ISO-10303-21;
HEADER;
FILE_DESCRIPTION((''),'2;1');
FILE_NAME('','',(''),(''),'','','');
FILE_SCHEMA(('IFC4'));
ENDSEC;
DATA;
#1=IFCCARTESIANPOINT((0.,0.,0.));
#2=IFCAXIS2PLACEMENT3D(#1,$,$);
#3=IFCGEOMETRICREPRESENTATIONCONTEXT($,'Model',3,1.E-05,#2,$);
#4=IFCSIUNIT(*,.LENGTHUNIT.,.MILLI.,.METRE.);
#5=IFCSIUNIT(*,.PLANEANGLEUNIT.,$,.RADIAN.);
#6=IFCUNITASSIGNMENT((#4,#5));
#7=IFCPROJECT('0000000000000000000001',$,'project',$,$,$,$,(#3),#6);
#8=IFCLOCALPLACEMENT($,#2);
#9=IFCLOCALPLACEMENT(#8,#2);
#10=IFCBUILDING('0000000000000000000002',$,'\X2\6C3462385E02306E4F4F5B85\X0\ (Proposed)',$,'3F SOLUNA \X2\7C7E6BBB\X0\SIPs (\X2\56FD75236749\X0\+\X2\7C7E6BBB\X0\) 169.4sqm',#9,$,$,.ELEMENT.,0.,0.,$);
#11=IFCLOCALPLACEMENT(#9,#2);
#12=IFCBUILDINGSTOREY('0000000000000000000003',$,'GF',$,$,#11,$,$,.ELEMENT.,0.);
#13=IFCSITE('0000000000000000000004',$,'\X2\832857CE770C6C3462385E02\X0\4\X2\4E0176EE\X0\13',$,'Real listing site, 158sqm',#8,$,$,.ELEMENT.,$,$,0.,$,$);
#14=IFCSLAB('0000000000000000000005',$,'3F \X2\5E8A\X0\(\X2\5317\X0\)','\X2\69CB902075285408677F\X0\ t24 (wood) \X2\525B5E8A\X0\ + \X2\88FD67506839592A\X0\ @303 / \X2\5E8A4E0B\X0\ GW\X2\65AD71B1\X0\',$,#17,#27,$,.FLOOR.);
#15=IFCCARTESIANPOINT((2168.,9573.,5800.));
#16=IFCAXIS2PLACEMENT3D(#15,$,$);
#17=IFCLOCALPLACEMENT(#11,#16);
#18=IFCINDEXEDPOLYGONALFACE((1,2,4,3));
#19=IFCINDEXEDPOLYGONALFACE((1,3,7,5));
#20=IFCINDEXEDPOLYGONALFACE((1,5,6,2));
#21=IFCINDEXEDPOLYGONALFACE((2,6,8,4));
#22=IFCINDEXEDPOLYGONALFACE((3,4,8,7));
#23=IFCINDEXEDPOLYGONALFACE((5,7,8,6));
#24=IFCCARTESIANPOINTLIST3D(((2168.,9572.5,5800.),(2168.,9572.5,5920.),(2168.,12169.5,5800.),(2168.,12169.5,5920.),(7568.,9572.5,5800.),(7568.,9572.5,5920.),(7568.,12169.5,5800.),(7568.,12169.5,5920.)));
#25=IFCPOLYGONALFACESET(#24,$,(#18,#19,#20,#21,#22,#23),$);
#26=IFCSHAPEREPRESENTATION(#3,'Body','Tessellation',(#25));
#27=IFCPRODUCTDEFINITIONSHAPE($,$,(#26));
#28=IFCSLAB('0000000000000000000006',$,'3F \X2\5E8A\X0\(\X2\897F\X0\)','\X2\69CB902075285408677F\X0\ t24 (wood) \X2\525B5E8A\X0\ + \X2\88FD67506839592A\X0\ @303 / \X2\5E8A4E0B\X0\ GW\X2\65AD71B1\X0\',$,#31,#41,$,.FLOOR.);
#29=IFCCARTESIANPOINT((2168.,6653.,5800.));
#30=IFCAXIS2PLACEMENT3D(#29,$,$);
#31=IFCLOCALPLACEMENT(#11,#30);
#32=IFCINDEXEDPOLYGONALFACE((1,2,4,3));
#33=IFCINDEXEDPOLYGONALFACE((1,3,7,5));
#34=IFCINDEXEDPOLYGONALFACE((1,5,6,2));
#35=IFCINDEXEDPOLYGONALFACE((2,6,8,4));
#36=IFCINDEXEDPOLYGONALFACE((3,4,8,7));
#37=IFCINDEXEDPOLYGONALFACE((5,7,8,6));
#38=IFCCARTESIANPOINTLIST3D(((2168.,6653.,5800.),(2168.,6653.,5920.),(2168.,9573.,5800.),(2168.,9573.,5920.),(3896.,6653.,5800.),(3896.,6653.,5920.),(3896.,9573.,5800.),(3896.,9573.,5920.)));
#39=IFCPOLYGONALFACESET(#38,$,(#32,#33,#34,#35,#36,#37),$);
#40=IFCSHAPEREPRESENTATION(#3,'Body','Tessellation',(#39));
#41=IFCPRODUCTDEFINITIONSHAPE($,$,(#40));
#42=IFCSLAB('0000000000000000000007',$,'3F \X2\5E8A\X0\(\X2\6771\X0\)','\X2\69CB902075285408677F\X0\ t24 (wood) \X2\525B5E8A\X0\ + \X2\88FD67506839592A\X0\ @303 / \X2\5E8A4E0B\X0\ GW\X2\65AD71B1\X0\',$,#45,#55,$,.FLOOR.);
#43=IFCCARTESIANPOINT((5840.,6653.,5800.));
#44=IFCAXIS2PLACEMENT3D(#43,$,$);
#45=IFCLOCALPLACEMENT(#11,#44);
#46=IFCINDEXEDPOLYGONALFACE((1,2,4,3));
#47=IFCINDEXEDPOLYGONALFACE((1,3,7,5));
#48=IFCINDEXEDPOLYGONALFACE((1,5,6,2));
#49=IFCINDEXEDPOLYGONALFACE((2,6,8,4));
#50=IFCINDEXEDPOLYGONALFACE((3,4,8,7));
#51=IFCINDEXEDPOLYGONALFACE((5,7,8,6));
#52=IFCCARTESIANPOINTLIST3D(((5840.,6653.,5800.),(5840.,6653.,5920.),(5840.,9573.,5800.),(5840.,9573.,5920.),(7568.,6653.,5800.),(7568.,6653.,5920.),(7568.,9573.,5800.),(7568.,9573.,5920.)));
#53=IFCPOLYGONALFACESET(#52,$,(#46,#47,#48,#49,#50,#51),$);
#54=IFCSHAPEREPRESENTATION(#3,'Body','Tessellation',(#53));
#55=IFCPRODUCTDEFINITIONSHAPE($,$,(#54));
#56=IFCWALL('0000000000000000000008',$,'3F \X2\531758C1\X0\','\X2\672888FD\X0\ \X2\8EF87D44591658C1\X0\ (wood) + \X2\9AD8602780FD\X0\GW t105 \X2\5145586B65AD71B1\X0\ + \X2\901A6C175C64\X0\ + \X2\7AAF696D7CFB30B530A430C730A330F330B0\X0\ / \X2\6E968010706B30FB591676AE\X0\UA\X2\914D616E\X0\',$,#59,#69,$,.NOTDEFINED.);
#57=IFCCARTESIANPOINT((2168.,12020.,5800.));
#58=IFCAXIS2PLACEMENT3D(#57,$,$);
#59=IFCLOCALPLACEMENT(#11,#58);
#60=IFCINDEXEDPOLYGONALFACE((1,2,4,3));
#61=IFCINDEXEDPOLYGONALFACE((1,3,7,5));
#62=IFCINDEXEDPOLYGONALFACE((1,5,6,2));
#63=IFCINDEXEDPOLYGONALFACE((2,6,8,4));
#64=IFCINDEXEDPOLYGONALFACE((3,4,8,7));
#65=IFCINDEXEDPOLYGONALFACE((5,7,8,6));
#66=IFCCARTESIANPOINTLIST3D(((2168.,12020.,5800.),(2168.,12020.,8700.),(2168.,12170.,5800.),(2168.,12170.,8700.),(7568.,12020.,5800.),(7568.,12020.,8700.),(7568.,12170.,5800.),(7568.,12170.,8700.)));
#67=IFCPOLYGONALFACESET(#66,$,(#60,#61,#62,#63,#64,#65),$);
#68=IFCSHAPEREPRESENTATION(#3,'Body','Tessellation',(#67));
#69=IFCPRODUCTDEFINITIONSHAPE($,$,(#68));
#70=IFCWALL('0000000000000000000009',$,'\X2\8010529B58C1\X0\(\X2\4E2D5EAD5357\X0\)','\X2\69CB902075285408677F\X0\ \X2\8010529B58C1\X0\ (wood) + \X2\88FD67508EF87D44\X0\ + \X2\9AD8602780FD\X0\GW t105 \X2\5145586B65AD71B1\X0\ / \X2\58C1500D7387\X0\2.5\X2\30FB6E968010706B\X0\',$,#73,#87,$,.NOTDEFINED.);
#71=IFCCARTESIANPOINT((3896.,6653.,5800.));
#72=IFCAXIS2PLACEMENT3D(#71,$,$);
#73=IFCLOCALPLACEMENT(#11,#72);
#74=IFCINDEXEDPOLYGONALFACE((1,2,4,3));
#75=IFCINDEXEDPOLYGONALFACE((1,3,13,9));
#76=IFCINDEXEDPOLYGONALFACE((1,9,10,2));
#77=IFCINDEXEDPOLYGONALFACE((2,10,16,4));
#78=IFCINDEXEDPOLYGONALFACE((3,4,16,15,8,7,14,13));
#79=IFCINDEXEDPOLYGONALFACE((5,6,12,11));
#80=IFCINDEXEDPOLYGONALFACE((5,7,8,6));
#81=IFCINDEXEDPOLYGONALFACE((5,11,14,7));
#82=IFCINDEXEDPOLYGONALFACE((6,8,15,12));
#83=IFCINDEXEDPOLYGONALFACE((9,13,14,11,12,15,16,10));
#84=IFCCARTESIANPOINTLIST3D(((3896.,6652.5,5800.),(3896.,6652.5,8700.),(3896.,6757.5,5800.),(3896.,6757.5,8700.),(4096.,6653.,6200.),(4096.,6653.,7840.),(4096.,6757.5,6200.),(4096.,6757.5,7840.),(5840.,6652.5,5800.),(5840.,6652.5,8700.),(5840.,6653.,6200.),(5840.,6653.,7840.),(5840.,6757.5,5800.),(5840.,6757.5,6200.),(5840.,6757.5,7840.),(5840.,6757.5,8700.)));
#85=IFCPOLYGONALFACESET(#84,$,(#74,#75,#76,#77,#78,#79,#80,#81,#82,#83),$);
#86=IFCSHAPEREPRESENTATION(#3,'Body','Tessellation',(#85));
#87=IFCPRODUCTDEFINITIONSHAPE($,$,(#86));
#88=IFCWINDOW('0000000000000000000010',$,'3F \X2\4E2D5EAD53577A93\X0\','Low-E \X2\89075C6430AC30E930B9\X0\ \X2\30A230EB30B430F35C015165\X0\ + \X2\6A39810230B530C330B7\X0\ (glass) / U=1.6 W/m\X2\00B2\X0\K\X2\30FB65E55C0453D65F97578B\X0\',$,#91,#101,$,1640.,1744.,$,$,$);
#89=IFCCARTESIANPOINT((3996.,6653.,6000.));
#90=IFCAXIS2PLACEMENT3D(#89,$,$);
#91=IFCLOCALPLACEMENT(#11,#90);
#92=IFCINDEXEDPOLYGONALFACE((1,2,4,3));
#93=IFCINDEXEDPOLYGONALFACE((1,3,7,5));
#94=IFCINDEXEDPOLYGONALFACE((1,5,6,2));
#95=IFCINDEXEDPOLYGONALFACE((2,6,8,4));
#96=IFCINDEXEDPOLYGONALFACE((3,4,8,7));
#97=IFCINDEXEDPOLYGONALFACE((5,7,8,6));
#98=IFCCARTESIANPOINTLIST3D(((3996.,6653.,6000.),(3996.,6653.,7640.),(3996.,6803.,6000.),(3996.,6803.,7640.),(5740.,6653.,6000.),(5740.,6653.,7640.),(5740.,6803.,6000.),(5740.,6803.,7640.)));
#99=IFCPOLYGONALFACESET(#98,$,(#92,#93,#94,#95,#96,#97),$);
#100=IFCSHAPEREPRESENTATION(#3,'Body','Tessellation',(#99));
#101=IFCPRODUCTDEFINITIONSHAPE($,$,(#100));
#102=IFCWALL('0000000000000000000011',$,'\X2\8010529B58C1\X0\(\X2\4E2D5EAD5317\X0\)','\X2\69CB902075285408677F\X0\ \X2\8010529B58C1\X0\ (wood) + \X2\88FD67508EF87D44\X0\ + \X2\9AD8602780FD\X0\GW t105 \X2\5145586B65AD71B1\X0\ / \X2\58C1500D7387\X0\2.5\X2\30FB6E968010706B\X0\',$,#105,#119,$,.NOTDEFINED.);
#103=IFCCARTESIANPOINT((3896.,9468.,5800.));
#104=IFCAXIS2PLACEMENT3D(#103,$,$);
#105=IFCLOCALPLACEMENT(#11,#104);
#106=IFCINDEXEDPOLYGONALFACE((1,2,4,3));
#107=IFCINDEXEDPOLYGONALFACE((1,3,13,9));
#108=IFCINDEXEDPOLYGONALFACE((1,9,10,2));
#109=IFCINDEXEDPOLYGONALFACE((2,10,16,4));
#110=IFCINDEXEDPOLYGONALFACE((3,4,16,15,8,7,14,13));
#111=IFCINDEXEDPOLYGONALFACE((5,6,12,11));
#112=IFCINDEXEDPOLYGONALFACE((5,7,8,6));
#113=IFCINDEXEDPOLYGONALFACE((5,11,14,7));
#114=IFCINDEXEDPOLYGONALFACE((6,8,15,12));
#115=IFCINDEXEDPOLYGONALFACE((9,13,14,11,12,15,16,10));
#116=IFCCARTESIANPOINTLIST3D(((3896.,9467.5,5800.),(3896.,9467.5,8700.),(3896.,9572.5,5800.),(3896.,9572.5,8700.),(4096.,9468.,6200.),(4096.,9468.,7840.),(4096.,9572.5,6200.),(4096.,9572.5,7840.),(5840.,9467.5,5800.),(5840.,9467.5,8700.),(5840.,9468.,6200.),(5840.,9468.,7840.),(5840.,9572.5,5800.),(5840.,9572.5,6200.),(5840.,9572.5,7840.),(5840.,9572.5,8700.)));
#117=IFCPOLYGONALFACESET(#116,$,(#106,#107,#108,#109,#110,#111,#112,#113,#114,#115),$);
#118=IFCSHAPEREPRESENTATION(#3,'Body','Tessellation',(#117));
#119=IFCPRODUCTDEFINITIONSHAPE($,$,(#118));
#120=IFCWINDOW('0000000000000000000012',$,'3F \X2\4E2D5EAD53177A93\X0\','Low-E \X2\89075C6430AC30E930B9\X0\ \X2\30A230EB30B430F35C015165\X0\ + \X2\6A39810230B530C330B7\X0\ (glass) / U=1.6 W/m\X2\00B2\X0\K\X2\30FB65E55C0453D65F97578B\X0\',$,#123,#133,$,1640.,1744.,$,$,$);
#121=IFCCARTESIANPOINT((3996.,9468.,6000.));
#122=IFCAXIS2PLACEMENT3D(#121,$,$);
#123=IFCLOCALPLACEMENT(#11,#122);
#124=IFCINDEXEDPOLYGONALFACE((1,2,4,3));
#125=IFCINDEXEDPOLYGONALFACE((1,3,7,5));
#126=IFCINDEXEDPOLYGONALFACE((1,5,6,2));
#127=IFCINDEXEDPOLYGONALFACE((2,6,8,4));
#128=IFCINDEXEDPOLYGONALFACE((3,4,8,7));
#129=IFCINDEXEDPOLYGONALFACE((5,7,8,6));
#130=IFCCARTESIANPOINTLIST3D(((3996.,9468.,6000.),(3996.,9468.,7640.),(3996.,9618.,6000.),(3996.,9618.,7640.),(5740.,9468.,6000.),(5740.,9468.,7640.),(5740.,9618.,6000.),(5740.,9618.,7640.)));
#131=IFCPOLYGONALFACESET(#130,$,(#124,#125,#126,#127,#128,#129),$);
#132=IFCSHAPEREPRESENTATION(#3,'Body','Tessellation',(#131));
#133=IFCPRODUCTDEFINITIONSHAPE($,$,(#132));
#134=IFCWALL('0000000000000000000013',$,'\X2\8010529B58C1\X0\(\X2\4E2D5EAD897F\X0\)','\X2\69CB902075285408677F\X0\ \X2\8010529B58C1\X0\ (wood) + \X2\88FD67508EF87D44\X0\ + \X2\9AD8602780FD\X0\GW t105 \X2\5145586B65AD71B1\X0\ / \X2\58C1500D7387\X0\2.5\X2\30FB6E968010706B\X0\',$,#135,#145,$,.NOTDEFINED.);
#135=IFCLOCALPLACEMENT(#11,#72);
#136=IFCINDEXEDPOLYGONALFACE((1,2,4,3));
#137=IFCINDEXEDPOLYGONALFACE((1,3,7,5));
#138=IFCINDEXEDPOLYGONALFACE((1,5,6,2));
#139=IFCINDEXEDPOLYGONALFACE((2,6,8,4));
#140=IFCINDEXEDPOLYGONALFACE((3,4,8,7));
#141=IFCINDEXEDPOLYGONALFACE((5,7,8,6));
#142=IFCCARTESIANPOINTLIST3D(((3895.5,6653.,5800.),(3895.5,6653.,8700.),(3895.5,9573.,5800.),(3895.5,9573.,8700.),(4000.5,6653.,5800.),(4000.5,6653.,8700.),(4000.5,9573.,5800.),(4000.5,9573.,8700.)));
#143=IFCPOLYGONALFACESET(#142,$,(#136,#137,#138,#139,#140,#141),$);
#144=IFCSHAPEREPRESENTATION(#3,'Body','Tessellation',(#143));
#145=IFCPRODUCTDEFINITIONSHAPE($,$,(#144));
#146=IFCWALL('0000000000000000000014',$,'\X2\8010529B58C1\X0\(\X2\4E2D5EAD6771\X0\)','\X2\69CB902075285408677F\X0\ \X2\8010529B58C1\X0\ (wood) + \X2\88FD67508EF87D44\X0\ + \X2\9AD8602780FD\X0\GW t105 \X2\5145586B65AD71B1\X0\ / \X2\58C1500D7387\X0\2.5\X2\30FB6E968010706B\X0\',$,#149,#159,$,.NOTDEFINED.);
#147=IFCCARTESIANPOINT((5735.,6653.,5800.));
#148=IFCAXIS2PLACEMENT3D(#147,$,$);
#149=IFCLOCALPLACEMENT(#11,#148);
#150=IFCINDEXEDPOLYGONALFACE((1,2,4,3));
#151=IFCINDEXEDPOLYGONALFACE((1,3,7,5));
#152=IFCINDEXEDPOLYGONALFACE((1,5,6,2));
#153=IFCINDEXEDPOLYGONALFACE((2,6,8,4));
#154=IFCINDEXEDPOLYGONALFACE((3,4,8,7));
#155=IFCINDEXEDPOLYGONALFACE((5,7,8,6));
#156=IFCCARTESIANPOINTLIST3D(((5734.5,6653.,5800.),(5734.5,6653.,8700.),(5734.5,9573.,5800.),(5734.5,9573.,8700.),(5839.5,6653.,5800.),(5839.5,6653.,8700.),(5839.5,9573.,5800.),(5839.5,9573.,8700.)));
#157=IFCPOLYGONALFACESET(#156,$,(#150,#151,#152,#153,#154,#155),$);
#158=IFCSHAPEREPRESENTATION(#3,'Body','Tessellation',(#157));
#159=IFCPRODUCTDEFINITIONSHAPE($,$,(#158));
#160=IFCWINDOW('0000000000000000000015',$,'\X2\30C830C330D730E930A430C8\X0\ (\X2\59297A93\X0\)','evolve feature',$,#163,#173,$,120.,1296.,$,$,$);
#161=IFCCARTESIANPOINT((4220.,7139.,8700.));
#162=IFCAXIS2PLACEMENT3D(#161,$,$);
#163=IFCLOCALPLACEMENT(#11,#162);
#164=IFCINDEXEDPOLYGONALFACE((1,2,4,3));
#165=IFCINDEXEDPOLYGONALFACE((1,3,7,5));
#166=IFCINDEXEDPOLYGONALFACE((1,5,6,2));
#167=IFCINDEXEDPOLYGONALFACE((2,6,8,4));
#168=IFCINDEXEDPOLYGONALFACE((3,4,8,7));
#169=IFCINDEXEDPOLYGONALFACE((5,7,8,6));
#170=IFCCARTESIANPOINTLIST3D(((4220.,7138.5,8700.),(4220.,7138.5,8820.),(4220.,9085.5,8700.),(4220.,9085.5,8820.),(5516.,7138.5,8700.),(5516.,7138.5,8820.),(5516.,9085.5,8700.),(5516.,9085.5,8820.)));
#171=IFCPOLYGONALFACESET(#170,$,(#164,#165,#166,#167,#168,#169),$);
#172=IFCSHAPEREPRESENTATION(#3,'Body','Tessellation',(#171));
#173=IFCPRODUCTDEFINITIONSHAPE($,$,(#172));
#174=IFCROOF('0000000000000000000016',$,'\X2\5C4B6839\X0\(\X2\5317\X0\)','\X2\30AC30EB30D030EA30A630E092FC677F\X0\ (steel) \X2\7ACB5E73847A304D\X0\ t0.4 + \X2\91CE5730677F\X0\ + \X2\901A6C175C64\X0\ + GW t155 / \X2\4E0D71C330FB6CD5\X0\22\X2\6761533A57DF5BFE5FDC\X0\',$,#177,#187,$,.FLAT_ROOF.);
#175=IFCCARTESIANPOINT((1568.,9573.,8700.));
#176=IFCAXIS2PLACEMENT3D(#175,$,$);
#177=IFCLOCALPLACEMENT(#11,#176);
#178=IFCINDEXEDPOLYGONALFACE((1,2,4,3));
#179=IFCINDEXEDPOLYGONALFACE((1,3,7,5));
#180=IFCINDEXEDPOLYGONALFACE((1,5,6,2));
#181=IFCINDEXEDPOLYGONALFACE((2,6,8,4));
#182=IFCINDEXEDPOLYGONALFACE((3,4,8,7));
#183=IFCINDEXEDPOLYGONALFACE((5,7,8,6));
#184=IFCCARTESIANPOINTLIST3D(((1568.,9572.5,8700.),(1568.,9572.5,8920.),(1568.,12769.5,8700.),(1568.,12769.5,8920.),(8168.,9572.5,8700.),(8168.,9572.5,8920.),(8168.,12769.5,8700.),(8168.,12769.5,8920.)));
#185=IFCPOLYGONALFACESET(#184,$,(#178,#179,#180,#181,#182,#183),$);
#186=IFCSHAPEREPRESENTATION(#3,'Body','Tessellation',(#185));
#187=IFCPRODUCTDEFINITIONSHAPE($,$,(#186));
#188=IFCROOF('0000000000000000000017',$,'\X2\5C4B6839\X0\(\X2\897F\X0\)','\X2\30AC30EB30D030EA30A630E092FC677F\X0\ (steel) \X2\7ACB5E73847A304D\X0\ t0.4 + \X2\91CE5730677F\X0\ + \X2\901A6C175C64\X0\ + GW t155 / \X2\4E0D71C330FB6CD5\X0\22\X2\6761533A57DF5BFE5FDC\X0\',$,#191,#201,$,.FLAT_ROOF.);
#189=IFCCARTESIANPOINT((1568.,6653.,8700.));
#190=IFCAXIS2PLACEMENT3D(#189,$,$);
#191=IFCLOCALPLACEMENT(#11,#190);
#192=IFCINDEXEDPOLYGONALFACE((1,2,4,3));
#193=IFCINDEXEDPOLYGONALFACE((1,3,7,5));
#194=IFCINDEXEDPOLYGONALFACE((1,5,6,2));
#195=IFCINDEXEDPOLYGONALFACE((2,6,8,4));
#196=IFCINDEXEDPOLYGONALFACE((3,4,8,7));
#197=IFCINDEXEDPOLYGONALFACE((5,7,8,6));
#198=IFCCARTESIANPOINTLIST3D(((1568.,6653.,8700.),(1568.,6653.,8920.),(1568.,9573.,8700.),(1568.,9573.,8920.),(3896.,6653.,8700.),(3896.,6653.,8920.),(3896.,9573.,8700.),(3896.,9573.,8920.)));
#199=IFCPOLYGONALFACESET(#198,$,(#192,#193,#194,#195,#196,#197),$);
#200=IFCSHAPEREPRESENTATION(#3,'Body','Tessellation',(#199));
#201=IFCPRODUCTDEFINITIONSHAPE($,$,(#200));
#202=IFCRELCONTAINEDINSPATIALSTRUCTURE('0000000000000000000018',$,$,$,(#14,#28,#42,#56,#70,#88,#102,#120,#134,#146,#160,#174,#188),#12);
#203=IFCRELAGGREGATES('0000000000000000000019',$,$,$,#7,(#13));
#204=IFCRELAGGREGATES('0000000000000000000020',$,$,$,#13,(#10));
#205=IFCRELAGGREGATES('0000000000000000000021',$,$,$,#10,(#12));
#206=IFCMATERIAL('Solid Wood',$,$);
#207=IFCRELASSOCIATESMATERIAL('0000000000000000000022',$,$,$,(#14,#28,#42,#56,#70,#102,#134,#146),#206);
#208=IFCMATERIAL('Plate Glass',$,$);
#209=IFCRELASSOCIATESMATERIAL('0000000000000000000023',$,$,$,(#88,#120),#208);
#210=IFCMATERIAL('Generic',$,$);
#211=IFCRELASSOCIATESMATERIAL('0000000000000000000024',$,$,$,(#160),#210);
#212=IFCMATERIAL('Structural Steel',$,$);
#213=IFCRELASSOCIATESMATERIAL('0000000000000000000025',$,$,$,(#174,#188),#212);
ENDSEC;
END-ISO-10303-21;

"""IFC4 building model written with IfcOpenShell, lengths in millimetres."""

from ifc_helpers import new_model, si_unit, frame, frame_2d, origin, place, context, project, spatial, rectangle, extrude, material, element, fill, save


model = new_model("IFC4")

# Units and contexts
model_context = context("Model", 3, precision=1e-05, world=origin())
ifc_project = project(units=[si_unit("LENGTHUNIT", "METRE", prefix="MILLI"), si_unit("PLANEANGLEUNIT", "RADIAN")], contexts=[model_context])

# Site, building, storey
site_placement = place(None, origin())
site = spatial("IfcSite", under=ifc_project, at=site_placement, Name="茨城県水戸市4丁目13", ObjectType="Real listing site, 158sqm", CompositionType="ELEMENT", RefElevation=0.0)
building_placement = place(site_placement, origin())
building = spatial("IfcBuilding", under=site, at=building_placement, Name="水戸市の住宅 (Proposed)", ObjectType="3F SOLUNA 籾殻SIPs (国産杉+籾殻) 169.4sqm", CompositionType="ELEMENT", ElevationOfRefHeight=0.0, ElevationOfTerrain=0.0)
storey_placement = place(building_placement, origin())
storey = spatial("IfcBuildingStorey", under=building, at=storey_placement, Name="GF", CompositionType="ELEMENT", Elevation=0.0)

# Slabs
ifc_material_1 = material(Name="Solid Wood")
slab_1_placement = place(storey_placement, frame((2168.0, 9573.0, 5800.0)))
element("IfcSlab", 1, at=slab_1_placement, inside=storey, material=ifc_material_1, Name="3F 床(北)", Description="構造用合板 t24 (wood) 剛床 + 製材根太 @303 / 床下 GW断熱", PredefinedType="FLOOR", context=model_context, shape_type="SweptSolid", body=[
    extrude(rectangle(XDim=5400.0, YDim=2597.0, at=frame_2d((2700.0, 1298.0))), frame((2168.0, 9573.0, 5800.0)), (0.0, 0.0, 1.0), 120.0),
])
slab_2_placement = place(storey_placement, frame((2168.0, 6653.0, 5800.0)))
element("IfcSlab", 2, at=slab_2_placement, inside=storey, material=ifc_material_1, Name="3F 床(西)", Description="構造用合板 t24 (wood) 剛床 + 製材根太 @303 / 床下 GW断熱", PredefinedType="FLOOR", context=model_context, shape_type="SweptSolid", body=[
    extrude(rectangle(XDim=1728.0, YDim=2920.0, at=frame_2d((864.0, 1460.0))), frame((2168.0, 6653.0, 5800.0)), (0.0, 0.0, 1.0), 120.0),
])
slab_3_placement = place(storey_placement, frame((5840.0, 6653.0, 5800.0)))
element("IfcSlab", 3, at=slab_3_placement, inside=storey, material=ifc_material_1, Name="3F 床(東)", Description="構造用合板 t24 (wood) 剛床 + 製材根太 @303 / 床下 GW断熱", PredefinedType="FLOOR", context=model_context, shape_type="SweptSolid", body=[
    extrude(rectangle(XDim=1728.0, YDim=2920.0, at=frame_2d((864.0, 1460.0))), frame((5840.0, 6653.0, 5800.0)), (0.0, 0.0, 1.0), 120.0),
])

# Wall
wall_1_placement = place(storey_placement, frame((2168.0, 12020.0, 5800.0)))
element("IfcWall", 4, at=wall_1_placement, inside=storey, material=ifc_material_1, Name="3F 北壁", Description="木製 軸組外壁 (wood) + 高性能GW t105 充填断熱 + 通気層 + 窯業系サイディング / 準耐火・外皮UA配慮", PredefinedType="NOTDEFINED", context=model_context, shape_type="SweptSolid", body=[
    extrude(rectangle(XDim=5400.0, YDim=150.0, at=frame_2d((2700.0, 75.0))), frame((2168.0, 12020.0, 5800.0)), (0.0, 0.0, 1.0), 2900.0),
])

# Walls, openings, windows
wall_2_placement = place(storey_placement, frame((3896.0, 6653.0, 5800.0)))
wall_2 = element("IfcWall", 5, at=wall_2_placement, inside=storey, material=ifc_material_1, Name="耐力壁(中庭南)", Description="構造用合板 耐力壁 (wood) + 製材軸組 + 高性能GW t105 充填断熱 / 壁倍率2.5・準耐火", PredefinedType="NOTDEFINED", context=model_context, shape_type="SweptSolid", body=[
    extrude(rectangle(XDim=1944.0, YDim=105.0, at=frame_2d((972.0, 52.0))), frame((3896.0, 6653.0, 5800.0)), (0.0, 0.0, 1.0), 2900.0),
])
opening_1_placement = place(storey_placement, frame((3996.0, 6653.0, 6000.0)))
opening_1 = element("IfcOpeningElement", 6, at=opening_1_placement, cuts=wall_2, PredefinedType="NOTDEFINED", context=model_context, shape_type="SweptSolid", body=[
    extrude(rectangle(XDim=1744.0, YDim=150.0, at=frame_2d((872.0, 75.0))), frame((3996.0, 6653.0, 6000.0)), (0.0, 0.0, 1.0), 1640.0),
])
ifc_material_2 = material(Name="Plate Glass")
window_1_placement = place(storey_placement, frame((3996.0, 6653.0, 6000.0)))
window_1 = element("IfcWindow", 7, at=window_1_placement, inside=storey, material=ifc_material_2, Name="3F 中庭南窓", Description="Low-E 複層ガラス アルゴン封入 + 樹脂サッシ (glass) / U=1.6 W/m²K・日射取得型", OverallHeight=1640.0, OverallWidth=1744.0, context=model_context, shape_type="SweptSolid", body=[
    extrude(rectangle(XDim=1744.0, YDim=150.0, at=frame_2d((872.0, 75.0))), frame((3996.0, 6653.0, 6000.0)), (0.0, 0.0, 1.0), 1640.0),
])
fill(opening_1, window_1)
wall_3_placement = place(storey_placement, frame((3896.0, 9468.0, 5800.0)))
wall_3 = element("IfcWall", 8, at=wall_3_placement, inside=storey, material=ifc_material_1, Name="耐力壁(中庭北)", Description="構造用合板 耐力壁 (wood) + 製材軸組 + 高性能GW t105 充填断熱 / 壁倍率2.5・準耐火", PredefinedType="NOTDEFINED", context=model_context, shape_type="SweptSolid", body=[
    extrude(rectangle(XDim=1944.0, YDim=105.0, at=frame_2d((972.0, 52.0))), frame((3896.0, 9468.0, 5800.0)), (0.0, 0.0, 1.0), 2900.0),
])
opening_2_placement = place(storey_placement, frame((3996.0, 9468.0, 6000.0)))
opening_2 = element("IfcOpeningElement", 9, at=opening_2_placement, cuts=wall_3, PredefinedType="NOTDEFINED", context=model_context, shape_type="SweptSolid", body=[
    extrude(rectangle(XDim=1744.0, YDim=150.0, at=frame_2d((872.0, 75.0))), frame((3996.0, 9468.0, 6000.0)), (0.0, 0.0, 1.0), 1640.0),
])
window_2_placement = place(storey_placement, frame((3996.0, 9468.0, 6000.0)))
window_2 = element("IfcWindow", 10, at=window_2_placement, inside=storey, material=ifc_material_2, Name="3F 中庭北窓", Description="Low-E 複層ガラス アルゴン封入 + 樹脂サッシ (glass) / U=1.6 W/m²K・日射取得型", OverallHeight=1640.0, OverallWidth=1744.0, context=model_context, shape_type="SweptSolid", body=[
    extrude(rectangle(XDim=1744.0, YDim=150.0, at=frame_2d((872.0, 75.0))), frame((3996.0, 9468.0, 6000.0)), (0.0, 0.0, 1.0), 1640.0),
])
fill(opening_2, window_2)

# Walls
wall_4_placement = place(storey_placement, frame((3896.0, 6653.0, 5800.0)))
element("IfcWall", 11, at=wall_4_placement, inside=storey, material=ifc_material_1, Name="耐力壁(中庭西)", Description="構造用合板 耐力壁 (wood) + 製材軸組 + 高性能GW t105 充填断熱 / 壁倍率2.5・準耐火", PredefinedType="NOTDEFINED", context=model_context, shape_type="SweptSolid", body=[
    extrude(rectangle(XDim=105.0, YDim=2920.0, at=frame_2d((52.0, 1460.0))), frame((3896.0, 6653.0, 5800.0)), (0.0, 0.0, 1.0), 2900.0),
])
wall_5_placement = place(storey_placement, frame((5735.0, 6653.0, 5800.0)))
element("IfcWall", 12, at=wall_5_placement, inside=storey, material=ifc_material_1, Name="耐力壁(中庭東)", Description="構造用合板 耐力壁 (wood) + 製材軸組 + 高性能GW t105 充填断熱 / 壁倍率2.5・準耐火", PredefinedType="NOTDEFINED", context=model_context, shape_type="SweptSolid", body=[
    extrude(rectangle(XDim=105.0, YDim=2920.0, at=frame_2d((52.0, 1460.0))), frame((5735.0, 6653.0, 5800.0)), (0.0, 0.0, 1.0), 2900.0),
])

# Window
ifc_material_3 = material(Name="Generic")
window_3_placement = place(storey_placement, frame((4220.0, 7139.0, 8700.0)))
element("IfcWindow", 13, at=window_3_placement, inside=storey, material=ifc_material_3, Name="トップライト (天窓)", Description="evolve feature", OverallHeight=120.0, OverallWidth=1296.0, context=model_context, shape_type="SweptSolid", body=[
    extrude(rectangle(XDim=1296.0, YDim=1947.0, at=frame_2d((648.0, 973.0))), frame((4220.0, 7139.0, 8700.0)), (0.0, 0.0, 1.0), 120.0),
])

# Roofs
ifc_material_4 = material(Name="Structural Steel")
for number, where, name in (
    (14, (1568.0, 9573.0, 8700.0), "屋根(北)"),
):
    element("IfcRoof", number, at=place(storey_placement, frame(where)), inside=storey, material=ifc_material_4, Name=name, Description="ガルバリウム鋼板 (steel) 立平葺き t0.4 + 野地板 + 通気層 + GW t155 / 不燃・法22条区域対応", PredefinedType="FLAT_ROOF", context=model_context, shape_type="SweptSolid", body=[
        extrude(rectangle(XDim=6600.0, YDim=3197.0, at=frame_2d((3300.0, 1598.0))), frame((1568.0, 9573.0, 8700.0)), (0.0, 0.0, 1.0), 220.0),
    ])
roof_1_placement = place(storey_placement, frame((1568.0, 6653.0, 8700.0)))
element("IfcRoof", 15, at=roof_1_placement, inside=storey, material=ifc_material_4, Name="屋根(西)", Description="ガルバリウム鋼板 (steel) 立平葺き t0.4 + 野地板 + 通気層 + GW t155 / 不燃・法22条区域対応", PredefinedType="FLAT_ROOF", context=model_context, shape_type="SweptSolid", body=[
    extrude(rectangle(XDim=2328.0, YDim=2920.0, at=frame_2d((1164.0, 1460.0))), frame((1568.0, 6653.0, 8700.0)), (0.0, 0.0, 1.0), 220.0),
])

save(model, "model.ifc")
